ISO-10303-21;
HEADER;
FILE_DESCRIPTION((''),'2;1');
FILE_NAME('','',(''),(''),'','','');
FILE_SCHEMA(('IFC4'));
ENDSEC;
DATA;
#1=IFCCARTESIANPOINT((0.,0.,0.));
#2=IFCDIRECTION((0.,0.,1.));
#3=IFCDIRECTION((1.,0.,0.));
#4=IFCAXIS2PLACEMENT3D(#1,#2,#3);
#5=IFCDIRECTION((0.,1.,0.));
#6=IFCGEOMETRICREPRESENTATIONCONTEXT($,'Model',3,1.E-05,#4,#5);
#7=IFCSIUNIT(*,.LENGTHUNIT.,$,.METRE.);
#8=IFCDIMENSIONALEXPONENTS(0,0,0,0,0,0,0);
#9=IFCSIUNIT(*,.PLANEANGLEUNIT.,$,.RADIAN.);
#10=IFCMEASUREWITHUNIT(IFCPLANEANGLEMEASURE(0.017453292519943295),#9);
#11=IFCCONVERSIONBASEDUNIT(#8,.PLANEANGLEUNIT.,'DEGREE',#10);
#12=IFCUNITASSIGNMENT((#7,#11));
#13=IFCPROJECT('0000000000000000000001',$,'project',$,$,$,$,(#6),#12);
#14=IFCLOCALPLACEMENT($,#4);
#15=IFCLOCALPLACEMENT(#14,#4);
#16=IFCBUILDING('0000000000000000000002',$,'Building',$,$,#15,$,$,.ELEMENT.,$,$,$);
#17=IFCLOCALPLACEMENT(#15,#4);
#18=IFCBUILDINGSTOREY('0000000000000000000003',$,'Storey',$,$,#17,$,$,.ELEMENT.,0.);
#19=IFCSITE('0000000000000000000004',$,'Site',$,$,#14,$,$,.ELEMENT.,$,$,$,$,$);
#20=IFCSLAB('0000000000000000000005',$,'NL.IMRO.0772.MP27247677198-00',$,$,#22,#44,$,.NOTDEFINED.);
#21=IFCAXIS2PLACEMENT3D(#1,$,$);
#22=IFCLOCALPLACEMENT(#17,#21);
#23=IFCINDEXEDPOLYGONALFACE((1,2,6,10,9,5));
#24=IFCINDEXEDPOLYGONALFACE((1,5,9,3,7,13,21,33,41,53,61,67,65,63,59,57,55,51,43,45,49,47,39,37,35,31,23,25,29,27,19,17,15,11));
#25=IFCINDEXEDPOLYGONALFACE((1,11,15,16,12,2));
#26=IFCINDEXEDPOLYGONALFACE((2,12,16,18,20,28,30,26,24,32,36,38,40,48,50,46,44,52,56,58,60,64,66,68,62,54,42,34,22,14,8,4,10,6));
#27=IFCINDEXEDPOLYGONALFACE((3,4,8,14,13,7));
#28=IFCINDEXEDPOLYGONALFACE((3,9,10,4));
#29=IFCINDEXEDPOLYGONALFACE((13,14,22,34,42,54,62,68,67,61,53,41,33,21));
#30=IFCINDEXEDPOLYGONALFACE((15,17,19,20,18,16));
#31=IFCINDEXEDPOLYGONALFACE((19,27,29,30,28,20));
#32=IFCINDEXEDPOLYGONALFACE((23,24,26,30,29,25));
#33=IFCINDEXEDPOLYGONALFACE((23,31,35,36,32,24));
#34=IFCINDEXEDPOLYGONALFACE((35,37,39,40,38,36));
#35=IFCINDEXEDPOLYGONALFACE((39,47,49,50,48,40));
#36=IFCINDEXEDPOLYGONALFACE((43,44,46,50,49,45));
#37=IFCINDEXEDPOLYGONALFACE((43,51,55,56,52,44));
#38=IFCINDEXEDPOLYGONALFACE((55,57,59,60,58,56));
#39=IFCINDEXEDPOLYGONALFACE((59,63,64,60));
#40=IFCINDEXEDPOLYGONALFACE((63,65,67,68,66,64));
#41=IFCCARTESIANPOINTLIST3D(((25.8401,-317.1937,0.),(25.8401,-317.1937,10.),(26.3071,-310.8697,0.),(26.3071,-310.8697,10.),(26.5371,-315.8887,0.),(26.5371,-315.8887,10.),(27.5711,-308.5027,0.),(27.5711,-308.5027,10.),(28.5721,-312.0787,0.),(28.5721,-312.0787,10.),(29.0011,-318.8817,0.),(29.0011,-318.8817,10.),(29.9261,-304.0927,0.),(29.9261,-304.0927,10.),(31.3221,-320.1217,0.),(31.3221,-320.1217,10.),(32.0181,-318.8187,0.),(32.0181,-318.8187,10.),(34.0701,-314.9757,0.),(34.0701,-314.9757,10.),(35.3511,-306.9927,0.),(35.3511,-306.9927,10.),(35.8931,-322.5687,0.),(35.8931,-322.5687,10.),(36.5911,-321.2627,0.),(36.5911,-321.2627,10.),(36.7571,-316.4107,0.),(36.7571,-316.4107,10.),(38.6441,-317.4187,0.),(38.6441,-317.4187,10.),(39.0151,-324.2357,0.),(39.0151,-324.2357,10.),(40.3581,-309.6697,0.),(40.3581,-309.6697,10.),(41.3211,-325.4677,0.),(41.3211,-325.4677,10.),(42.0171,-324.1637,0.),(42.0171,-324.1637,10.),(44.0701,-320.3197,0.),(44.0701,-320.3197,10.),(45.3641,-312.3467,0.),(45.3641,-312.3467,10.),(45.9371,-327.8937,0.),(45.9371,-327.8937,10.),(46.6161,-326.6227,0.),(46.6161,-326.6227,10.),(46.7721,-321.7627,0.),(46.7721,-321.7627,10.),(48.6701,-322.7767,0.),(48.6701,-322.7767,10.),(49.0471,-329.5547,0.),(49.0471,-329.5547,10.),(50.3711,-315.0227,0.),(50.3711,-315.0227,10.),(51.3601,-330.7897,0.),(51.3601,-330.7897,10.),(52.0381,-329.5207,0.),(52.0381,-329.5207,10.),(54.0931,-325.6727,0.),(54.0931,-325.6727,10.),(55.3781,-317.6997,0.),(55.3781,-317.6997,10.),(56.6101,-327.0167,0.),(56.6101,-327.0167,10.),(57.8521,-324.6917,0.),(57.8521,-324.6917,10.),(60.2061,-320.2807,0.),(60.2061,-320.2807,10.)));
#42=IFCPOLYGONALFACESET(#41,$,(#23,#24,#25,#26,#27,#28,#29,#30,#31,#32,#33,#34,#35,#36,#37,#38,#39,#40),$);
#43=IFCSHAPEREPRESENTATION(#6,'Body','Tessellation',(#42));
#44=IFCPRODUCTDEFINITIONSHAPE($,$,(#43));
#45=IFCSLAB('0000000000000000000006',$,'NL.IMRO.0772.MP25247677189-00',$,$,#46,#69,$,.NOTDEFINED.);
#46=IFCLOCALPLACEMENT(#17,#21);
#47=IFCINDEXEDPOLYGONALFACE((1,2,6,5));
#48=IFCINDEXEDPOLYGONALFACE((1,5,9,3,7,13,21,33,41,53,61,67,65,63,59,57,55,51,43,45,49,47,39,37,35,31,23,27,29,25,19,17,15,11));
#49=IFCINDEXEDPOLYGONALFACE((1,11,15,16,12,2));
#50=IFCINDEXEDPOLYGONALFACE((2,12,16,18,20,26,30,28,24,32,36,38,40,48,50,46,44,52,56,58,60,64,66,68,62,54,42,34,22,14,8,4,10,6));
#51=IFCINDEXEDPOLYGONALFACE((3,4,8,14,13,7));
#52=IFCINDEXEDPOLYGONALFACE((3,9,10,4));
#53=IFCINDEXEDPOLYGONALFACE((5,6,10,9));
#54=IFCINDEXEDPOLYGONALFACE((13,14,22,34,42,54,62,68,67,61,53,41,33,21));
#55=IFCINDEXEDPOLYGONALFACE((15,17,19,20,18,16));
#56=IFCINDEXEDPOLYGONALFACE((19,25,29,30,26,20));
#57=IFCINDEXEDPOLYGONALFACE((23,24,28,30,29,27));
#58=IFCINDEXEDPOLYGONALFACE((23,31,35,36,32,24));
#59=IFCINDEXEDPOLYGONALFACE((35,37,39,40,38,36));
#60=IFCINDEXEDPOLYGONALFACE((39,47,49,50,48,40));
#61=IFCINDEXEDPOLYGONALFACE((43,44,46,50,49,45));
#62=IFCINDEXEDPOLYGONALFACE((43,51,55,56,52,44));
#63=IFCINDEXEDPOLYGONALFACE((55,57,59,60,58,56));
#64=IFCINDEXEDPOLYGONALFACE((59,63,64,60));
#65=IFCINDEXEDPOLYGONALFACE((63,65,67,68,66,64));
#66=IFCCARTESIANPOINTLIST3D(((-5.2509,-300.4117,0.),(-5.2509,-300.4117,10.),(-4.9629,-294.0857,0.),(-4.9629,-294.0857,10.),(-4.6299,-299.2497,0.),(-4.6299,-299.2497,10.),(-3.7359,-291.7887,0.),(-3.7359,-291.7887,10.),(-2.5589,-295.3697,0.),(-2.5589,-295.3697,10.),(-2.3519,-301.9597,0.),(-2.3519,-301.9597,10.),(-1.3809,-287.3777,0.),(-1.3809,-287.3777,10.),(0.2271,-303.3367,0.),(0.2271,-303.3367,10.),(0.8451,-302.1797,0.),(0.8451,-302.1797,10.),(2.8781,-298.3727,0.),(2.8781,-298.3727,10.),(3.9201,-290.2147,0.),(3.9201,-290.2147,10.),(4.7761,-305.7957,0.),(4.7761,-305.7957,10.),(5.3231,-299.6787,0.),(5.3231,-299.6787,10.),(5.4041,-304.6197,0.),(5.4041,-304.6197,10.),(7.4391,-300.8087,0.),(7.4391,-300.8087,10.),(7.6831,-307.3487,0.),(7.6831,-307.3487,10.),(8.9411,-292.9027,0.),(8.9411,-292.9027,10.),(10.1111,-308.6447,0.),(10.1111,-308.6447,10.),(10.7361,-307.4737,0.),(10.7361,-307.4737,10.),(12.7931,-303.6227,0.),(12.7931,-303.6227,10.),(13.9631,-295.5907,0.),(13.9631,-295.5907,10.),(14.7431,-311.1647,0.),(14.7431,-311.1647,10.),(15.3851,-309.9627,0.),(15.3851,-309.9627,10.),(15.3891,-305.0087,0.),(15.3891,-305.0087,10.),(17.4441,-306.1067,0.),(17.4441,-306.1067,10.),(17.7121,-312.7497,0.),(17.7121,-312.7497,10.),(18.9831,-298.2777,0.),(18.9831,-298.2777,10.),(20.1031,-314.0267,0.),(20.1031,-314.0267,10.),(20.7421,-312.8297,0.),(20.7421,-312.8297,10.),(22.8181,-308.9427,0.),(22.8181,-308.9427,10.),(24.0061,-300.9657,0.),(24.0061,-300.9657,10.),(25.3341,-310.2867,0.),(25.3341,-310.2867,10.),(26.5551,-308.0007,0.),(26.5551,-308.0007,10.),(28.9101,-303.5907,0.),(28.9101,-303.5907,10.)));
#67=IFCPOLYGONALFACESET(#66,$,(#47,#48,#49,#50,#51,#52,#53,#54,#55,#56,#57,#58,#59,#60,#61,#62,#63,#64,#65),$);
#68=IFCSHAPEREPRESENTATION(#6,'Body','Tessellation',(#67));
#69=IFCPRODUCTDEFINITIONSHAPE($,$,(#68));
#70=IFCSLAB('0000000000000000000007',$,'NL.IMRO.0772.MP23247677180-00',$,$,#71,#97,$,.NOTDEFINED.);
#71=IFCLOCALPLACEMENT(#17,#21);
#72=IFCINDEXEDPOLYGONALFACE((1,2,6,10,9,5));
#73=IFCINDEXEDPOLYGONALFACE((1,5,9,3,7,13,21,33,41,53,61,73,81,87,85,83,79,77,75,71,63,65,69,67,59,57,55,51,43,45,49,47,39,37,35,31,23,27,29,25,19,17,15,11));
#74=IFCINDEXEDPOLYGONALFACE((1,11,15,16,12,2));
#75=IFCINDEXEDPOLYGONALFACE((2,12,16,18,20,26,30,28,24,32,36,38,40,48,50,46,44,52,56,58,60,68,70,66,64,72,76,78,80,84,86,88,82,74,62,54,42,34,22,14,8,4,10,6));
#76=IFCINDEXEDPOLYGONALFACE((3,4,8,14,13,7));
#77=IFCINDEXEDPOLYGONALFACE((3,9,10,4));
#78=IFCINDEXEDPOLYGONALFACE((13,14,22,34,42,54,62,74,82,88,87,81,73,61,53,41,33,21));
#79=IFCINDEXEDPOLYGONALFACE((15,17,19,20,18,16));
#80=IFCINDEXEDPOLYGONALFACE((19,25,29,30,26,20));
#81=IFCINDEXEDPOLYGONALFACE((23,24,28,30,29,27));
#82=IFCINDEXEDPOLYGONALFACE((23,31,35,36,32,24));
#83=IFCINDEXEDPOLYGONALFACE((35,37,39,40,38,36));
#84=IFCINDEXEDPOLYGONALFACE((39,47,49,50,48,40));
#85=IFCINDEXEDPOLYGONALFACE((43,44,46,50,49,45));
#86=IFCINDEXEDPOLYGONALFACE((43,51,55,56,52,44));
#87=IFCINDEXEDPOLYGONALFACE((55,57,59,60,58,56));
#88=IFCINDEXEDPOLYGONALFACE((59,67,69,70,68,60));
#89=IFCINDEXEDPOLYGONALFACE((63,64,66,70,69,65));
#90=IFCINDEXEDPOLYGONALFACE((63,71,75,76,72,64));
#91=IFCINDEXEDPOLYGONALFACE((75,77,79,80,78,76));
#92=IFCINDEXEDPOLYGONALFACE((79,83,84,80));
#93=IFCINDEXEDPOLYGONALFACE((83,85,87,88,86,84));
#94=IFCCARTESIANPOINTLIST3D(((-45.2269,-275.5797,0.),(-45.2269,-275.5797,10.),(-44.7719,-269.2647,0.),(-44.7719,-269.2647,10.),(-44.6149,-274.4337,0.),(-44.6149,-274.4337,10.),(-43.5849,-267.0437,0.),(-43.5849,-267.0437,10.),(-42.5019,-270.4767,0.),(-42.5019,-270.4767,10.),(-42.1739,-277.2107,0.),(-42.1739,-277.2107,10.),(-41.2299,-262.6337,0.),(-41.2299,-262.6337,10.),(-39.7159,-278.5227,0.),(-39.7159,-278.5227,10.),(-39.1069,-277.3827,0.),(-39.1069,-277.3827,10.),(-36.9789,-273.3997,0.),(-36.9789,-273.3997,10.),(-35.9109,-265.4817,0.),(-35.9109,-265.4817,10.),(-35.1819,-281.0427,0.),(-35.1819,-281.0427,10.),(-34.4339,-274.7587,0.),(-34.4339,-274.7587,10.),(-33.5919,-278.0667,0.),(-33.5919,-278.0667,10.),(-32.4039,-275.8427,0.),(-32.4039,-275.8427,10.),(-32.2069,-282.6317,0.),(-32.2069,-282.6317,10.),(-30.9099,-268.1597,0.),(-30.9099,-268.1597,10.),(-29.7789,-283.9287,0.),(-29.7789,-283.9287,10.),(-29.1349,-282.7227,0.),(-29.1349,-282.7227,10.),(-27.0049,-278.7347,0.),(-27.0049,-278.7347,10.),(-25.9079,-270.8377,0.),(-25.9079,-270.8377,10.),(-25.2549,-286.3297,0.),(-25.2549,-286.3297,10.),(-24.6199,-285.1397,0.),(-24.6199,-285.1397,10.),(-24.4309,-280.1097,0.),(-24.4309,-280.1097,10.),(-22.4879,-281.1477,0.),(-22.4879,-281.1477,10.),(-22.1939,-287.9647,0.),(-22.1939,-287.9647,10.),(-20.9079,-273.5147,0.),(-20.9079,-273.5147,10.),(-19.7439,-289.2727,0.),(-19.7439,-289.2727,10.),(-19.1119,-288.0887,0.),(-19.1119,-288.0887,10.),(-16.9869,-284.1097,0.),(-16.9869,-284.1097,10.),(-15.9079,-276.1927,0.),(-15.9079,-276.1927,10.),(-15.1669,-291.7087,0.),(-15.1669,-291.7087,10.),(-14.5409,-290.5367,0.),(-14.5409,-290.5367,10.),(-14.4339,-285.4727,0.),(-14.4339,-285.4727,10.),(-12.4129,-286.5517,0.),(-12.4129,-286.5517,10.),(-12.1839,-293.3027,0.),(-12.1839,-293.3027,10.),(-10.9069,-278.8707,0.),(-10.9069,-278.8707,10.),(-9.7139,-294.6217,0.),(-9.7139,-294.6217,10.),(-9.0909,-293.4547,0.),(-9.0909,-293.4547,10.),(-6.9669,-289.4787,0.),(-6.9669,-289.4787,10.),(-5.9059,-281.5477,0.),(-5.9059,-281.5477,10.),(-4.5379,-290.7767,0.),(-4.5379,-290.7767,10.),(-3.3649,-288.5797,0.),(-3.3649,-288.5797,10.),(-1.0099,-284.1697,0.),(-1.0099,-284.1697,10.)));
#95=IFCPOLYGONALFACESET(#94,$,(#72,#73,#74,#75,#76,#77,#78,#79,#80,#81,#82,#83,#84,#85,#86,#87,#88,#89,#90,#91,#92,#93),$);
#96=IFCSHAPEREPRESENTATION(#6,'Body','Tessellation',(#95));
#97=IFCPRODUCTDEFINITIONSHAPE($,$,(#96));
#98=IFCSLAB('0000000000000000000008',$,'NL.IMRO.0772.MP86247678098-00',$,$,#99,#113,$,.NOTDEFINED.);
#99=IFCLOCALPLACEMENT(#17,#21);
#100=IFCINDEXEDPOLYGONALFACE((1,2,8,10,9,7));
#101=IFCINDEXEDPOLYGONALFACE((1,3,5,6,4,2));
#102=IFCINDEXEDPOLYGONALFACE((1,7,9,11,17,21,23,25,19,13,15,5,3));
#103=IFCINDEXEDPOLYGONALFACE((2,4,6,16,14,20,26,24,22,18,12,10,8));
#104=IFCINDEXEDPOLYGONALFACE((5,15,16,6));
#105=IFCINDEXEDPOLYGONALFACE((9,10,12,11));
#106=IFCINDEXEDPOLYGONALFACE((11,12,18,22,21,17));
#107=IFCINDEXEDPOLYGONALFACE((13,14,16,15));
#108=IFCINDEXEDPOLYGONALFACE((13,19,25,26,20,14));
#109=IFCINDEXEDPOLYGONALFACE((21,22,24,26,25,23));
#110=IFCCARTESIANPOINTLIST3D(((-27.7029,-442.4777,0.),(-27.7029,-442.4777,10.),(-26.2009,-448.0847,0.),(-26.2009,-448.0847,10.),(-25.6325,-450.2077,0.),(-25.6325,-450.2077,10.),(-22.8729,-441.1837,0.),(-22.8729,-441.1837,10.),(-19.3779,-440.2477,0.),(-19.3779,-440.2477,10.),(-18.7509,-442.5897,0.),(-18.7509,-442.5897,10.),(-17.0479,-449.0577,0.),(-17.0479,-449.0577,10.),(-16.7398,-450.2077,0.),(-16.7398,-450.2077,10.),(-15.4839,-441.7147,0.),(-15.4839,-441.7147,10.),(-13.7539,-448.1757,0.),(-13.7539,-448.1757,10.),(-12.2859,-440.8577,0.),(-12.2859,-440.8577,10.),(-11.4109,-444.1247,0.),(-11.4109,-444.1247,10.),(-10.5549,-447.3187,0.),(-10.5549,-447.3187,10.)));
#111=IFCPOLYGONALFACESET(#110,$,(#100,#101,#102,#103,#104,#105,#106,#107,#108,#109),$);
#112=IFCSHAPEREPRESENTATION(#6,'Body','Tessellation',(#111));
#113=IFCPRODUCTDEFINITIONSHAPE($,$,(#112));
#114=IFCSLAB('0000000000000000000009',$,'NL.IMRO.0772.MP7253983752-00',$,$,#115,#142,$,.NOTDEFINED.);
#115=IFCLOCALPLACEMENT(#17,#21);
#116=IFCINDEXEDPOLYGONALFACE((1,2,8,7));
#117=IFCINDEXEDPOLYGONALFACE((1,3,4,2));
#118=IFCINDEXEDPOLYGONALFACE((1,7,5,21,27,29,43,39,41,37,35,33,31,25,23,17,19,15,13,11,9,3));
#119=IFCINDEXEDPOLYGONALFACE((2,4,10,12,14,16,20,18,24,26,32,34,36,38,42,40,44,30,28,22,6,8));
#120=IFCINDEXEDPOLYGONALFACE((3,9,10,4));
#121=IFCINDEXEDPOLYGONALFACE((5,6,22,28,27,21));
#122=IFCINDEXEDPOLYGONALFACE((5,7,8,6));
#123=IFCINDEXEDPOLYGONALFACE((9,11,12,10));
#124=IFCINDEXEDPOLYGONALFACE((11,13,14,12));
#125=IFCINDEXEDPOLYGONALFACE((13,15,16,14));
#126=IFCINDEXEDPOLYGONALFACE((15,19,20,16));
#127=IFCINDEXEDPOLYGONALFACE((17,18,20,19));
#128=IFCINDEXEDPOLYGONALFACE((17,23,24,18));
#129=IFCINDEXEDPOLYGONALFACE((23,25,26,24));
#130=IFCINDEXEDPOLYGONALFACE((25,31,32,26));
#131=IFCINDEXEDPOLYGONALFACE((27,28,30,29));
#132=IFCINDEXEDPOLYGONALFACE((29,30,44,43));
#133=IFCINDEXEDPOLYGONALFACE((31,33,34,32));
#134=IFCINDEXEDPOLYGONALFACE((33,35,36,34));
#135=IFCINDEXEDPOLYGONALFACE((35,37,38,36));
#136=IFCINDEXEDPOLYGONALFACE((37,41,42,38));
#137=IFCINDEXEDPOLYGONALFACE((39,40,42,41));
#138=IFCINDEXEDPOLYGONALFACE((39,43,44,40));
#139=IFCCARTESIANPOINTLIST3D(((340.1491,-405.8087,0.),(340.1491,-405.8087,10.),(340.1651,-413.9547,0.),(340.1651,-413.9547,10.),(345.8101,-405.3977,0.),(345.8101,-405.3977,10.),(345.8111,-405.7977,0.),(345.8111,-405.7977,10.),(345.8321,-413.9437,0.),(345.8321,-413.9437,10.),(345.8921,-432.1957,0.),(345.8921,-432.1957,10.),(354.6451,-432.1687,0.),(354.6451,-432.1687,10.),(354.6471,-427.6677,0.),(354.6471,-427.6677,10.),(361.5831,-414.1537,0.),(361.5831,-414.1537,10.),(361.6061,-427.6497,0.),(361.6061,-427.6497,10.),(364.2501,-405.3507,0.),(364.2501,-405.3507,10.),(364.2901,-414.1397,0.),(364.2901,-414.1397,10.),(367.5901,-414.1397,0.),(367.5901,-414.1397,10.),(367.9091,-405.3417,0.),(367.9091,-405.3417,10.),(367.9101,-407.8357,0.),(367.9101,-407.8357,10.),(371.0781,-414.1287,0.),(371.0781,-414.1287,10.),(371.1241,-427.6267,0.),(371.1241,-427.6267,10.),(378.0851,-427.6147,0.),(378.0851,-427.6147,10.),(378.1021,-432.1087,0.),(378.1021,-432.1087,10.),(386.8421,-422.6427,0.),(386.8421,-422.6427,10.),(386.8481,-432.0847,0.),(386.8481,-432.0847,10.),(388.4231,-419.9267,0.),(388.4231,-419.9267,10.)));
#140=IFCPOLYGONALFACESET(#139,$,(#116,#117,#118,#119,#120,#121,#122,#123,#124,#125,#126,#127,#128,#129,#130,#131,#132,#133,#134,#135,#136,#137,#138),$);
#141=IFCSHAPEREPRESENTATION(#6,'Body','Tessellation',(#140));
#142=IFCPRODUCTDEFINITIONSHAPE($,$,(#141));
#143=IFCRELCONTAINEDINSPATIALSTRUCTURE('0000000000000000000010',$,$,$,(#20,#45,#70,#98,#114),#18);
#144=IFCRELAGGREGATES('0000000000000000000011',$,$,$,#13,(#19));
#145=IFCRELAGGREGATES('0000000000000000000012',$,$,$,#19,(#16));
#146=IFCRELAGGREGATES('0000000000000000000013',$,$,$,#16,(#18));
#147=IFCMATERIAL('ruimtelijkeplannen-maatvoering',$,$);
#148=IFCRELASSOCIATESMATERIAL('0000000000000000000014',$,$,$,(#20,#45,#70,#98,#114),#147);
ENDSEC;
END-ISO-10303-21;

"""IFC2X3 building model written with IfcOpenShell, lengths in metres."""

from ifc_helpers import new_model, entity, si_unit, converted_unit, direction, origin_with_axes, place, context, project, spatial, polyline, outline, extrude, material, element, save


model = new_model("IFC2X3")

# Units and contexts
model_context = context("Model", 3, precision=1e-05, world=origin_with_axes(), true_north=direction((0.0, 1.0, 0.0)))
ifc_project = project(units=[si_unit("LENGTHUNIT", "METRE"), converted_unit("PLANEANGLEUNIT", "DEGREE", entity("IfcPlaneAngleMeasure", 0.017453292519943295), si_unit("PLANEANGLEUNIT", "RADIAN"), dimensions=[0, 0, 0, 0, 0, 0, 0])], contexts=[model_context])

# Site, building, storey
site_placement = place(None, origin_with_axes())
site = spatial("IfcSite", under=ifc_project, at=site_placement, Name="Site", CompositionType="ELEMENT")
building_placement = place(site_placement, origin_with_axes())
building = spatial("IfcBuilding", under=site, at=building_placement, Name="Building", CompositionType="ELEMENT")
storey_placement = place(building_placement, origin_with_axes())
storey = spatial("IfcBuildingStorey", under=building, at=storey_placement, Name="Storey", CompositionType="ELEMENT", Elevation=0.0)

# Slabs
ifc_material = material(Name="ruimtelijkeplannen-maatvoering")
slab_1_placement = place(storey_placement, origin_with_axes())
element("IfcSlab", 1, at=slab_1_placement, inside=storey, material=ifc_material, Name="NL.IMRO.0772.MP27247677198-00", PredefinedType="NOTDEFINED", context=model_context, shape_type="SweptSolid", body=[
    extrude(outline(polyline([(52.0381, -329.5207), (51.3601, -330.7897), (49.0471, -329.5547), (45.9371, -327.8937), (46.6161, -326.6227), (48.6701, -322.7767), (46.7721, -321.7627), (44.0701, -320.3197), (42.0171, -324.1637), (41.3211, -325.4677), (39.0151, -324.2357), (35.8931, -322.5687), (36.5911, -321.2627), (38.6441, -317.4187), (36.7571, -316.4107), (34.0701, -314.9757), (32.0181, -318.8187), (31.3221, -320.1217), (29.0011, -318.8817), (25.8401, -317.1937), (26.5371, -315.8887), (28.5721, -312.0787), (26.3071, -310.8697), (27.5711, -308.5027), (29.9261, -304.0927), (35.3511, -306.9927), (40.3581, -309.6697), (45.3641, -312.3467), (50.3711, -315.0227), (55.3781, -317.6997), (60.2061, -320.2807), (57.8521, -324.6917), (56.6101, -327.0167), (54.0931, -325.6727), (52.0381, -329.5207)])), origin_with_axes(), (0.0, 0.0, 1.0), 10.0),
])
slab_2_placement = place(storey_placement, origin_with_axes())
element("IfcSlab", 2, at=slab_2_placement, inside=storey, material=ifc_material, Name="NL.IMRO.0772.MP25247677189-00", PredefinedType="NOTDEFINED", context=model_context, shape_type="SweptSolid", body=[
    extrude(outline(polyline([(22.8181, -308.9427), (20.7421, -312.8297), (20.1031, -314.0267), (17.7121, -312.7497), (14.7431, -311.1647), (15.3851, -309.9627), (17.4441, -306.1067), (15.3891, -305.0087), (12.7931, -303.6227), (10.7361, -307.4737), (10.1111, -308.6447), (7.6831, -307.3487), (4.7761, -305.7957), (5.4041, -304.6197), (7.4391, -300.8087), (5.3231, -299.6787), (2.8781, -298.3727), (0.8451, -302.1797), (0.2271, -303.3367), (-2.3519, -301.9597), (-5.2509, -300.4117), (-4.6299, -299.2497), (-2.5589, -295.3697), (-4.9629, -294.0857), (-3.7359, -291.7887), (-1.3809, -287.3777), (3.9201, -290.2147), (8.9411, -292.9027), (13.9631, -295.5907), (18.9831, -298.2777), (24.0061, -300.9657), (28.9101, -303.5907), (26.5551, -308.0007), (25.3341, -310.2867), (22.8181, -308.9427)])), origin_with_axes(), (0.0, 0.0, 1.0), 10.0),
])
slab_3_placement = place(storey_placement, origin_with_axes())
element("IfcSlab", 3, at=slab_3_placement, inside=storey, material=ifc_material, Name="NL.IMRO.0772.MP23247677180-00", PredefinedType="NOTDEFINED", context=model_context, shape_type="SweptSolid", body=[
    extrude(outline(polyline([(-1.0099, -284.1697), (-3.3649, -288.5797), (-4.5379, -290.7767), (-6.9669, -289.4787), (-9.0909, -293.4547), (-9.7139, -294.6217), (-12.1839, -293.3027), (-15.1669, -291.7087), (-14.5409, -290.5367), (-12.4129, -286.5517), (-14.4339, -285.4727), (-16.9869, -284.1097), (-19.1119, -288.0887), (-19.7439, -289.2727), (-22.1939, -287.9647), (-25.2549, -286.3297), (-24.6199, -285.1397), (-22.4879, -281.1477), (-24.4309, -280.1097), (-27.0049, -278.7347), (-29.1349, -282.7227), (-29.7789, -283.9287), (-32.2069, -282.6317), (-35.1819, -281.0427), (-33.5919, -278.0667), (-32.4039, -275.8427), (-34.4339, -274.7587), (-36.9789, -273.3997), (-39.1069, -277.3827), (-39.7159, -278.5227), (-42.1739, -277.2107), (-45.2269, -275.5797), (-44.6149, -274.4337), (-42.5019, -270.4767), (-44.7719, -269.2647), (-43.5849, -267.0437), (-41.2299, -262.6337), (-35.9109, -265.4817), (-30.9099, -268.1597), (-25.9079, -270.8377), (-20.9079, -273.5147), (-15.9079, -276.1927), (-10.9069, -278.8707), (-5.9059, -281.5477), (-1.0099, -284.1697)])), origin_with_axes(), (0.0, 0.0, 1.0), 10.0),
])
slab_4_placement = place(storey_placement, origin_with_axes())
element("IfcSlab", 4, at=slab_4_placement, inside=storey, material=ifc_material, Name="NL.IMRO.0772.MP86247678098-00", PredefinedType="NOTDEFINED", context=model_context, shape_type="SweptSolid", body=[
    extrude(outline(polyline([(-26.2009, -448.0847), (-27.7029, -442.4777), (-22.8729, -441.1837), (-19.3779, -440.2477), (-18.7509, -442.5897), (-15.4839, -441.7147), (-12.2859, -440.8577), (-11.4109, -444.1247), (-10.5549, -447.3187), (-13.7539, -448.1757), (-17.0479, -449.0577), (-16.7398, -450.2077), (-25.6325, -450.2077), (-26.2009, -448.0847)])), origin_with_axes(), (0.0, 0.0, 1.0), 10.0),
])
slab_5_placement = place(storey_placement, origin_with_axes())
element("IfcSlab", 5, at=slab_5_placement, inside=storey, material=ifc_material, Name="NL.IMRO.0772.MP7253983752-00", PredefinedType="NOTDEFINED", context=model_context, shape_type="SweptSolid", body=[
    extrude(outline(polyline([(340.1651, -413.9547), (340.1491, -405.8087), (345.8111, -405.7977), (345.8101, -405.3977), (364.2501, -405.3507), (367.9091, -405.3417), (367.9101, -407.8357), (388.4231, -419.9267), (386.8421, -422.6427), (386.8481, -432.0847), (378.1021, -432.1087), (378.0851, -427.6147), (371.1241, -427.6267), (371.0781, -414.1287), (367.5901, -414.1397), (364.2901, -414.1397), (361.5831, -414.1537), (361.6061, -427.6497), (354.6471, -427.6677), (354.6451, -432.1687), (345.8921, -432.1957), (345.8321, -413.9437), (340.1651, -413.9547)])), origin_with_axes(), (0.0, 0.0, 1.0), 10.0),
])

save(model, "model.ifc")
